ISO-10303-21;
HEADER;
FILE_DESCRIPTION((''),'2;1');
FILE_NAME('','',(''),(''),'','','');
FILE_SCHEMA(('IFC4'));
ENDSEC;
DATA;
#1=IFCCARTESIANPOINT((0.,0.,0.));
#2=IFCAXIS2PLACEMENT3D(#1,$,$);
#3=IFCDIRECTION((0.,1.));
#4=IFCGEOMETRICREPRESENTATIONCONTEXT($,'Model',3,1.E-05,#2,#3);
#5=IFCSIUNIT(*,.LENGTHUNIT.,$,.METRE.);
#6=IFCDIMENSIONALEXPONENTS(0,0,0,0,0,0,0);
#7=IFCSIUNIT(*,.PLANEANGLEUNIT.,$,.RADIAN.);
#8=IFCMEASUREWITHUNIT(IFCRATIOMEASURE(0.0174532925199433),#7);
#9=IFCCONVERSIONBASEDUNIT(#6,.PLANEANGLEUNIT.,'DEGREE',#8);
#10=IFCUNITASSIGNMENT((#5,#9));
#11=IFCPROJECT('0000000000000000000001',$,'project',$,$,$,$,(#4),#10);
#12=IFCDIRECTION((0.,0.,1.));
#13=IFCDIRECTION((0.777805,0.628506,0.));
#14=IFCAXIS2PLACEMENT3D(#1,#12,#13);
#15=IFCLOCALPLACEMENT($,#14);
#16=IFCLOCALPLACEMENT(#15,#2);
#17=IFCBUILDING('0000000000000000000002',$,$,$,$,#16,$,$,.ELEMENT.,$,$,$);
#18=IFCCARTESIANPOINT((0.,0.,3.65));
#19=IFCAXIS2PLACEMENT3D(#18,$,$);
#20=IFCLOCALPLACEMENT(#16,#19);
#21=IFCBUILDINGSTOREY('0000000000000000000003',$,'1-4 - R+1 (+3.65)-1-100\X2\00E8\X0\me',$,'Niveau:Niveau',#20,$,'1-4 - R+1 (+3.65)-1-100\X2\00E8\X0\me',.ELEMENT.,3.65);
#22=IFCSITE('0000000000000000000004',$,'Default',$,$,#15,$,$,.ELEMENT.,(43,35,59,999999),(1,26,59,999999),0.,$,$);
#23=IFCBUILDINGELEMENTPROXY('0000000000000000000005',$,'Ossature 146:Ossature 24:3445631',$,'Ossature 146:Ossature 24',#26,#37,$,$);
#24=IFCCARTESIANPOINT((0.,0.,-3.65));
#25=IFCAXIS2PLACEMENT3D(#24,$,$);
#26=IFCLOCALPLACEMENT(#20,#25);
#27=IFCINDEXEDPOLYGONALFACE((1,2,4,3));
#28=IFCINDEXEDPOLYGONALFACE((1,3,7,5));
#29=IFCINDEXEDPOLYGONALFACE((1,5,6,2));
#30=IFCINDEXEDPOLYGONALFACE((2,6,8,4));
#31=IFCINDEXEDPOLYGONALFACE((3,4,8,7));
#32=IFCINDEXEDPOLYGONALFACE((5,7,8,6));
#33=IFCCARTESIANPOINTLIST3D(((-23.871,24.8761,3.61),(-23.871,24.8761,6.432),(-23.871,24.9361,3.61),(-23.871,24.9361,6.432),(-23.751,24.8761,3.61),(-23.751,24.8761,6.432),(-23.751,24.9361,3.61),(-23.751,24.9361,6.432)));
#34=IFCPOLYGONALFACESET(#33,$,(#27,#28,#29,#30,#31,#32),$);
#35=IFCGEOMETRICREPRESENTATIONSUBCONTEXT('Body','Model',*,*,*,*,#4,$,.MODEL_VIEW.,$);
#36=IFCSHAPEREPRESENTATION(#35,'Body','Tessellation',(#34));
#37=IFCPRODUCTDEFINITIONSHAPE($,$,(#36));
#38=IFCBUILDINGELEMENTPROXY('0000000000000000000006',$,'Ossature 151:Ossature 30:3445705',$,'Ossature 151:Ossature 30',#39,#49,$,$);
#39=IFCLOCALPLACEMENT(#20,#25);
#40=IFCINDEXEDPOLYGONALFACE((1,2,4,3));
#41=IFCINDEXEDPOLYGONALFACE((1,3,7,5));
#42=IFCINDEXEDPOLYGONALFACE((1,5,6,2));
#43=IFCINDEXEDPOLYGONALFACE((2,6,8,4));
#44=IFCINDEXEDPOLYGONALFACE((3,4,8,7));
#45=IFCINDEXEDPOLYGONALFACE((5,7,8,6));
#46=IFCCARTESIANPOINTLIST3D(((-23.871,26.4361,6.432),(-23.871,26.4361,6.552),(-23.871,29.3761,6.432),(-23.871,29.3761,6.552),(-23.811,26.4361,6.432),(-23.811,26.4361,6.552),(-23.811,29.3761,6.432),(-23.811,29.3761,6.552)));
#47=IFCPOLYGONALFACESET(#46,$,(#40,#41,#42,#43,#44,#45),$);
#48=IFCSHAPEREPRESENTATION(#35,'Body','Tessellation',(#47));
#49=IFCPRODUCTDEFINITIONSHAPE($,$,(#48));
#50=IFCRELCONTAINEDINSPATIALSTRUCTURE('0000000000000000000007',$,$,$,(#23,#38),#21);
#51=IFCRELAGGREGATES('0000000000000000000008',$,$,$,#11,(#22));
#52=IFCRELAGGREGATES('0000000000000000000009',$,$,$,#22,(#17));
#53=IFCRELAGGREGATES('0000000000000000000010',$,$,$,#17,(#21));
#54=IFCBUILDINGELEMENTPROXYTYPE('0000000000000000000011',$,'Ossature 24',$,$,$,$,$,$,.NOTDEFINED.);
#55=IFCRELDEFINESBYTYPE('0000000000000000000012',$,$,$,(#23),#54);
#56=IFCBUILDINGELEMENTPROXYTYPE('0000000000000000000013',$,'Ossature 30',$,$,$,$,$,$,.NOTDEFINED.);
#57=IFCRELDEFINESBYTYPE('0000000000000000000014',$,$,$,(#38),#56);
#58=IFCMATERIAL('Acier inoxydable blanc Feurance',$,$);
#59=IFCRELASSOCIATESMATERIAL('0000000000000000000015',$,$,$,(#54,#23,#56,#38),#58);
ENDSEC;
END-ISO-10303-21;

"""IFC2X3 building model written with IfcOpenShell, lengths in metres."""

from ifc_helpers import new_model, entity, si_unit, converted_unit, direction, frame, frame_2d, origin, origin_2d_with_axis, place, context, subcontext, project, spatial, rectangle, extrude, source, transform, mapped, material, type_object, type_shapes, element, save


model = new_model("IFC2X3")

# Units and contexts
model_context = context("Model", 3, precision=1e-05, world=origin(), true_north=direction((0.0, 1.0)))
body_context = subcontext(model_context, "Body", "Model", "MODEL_VIEW")
ifc_project = project(units=[si_unit("LENGTHUNIT", "METRE"), converted_unit("PLANEANGLEUNIT", "DEGREE", entity("IfcRatioMeasure", 0.0174532925199433), si_unit("PLANEANGLEUNIT", "RADIAN"), dimensions=[0, 0, 0, 0, 0, 0, 0])], contexts=[model_context])

# Site, building, storey
site_placement = place(None, frame((0.0, 0.0, 0.0), z_axis=(0.0, 0.0, 1.0), x_axis=(0.777805, 0.628506, 0.0)))
site = spatial("IfcSite", under=ifc_project, at=site_placement, Name="Default", CompositionType="ELEMENT", RefLatitude=(43, 35, 59, 999999), RefLongitude=(1, 26, 59, 999999), RefElevation=0.0)
building_placement = place(site_placement, origin())
building = spatial("IfcBuilding", under=site, at=building_placement, CompositionType="ELEMENT")
storey_placement = place(building_placement, frame((0.0, 0.0, 3.65)))
storey = spatial("IfcBuildingStorey", under=building, at=storey_placement, Name="1-4 - R+1 (+3.65)-1-100ème", ObjectType="Niveau:Niveau", LongName="1-4 - R+1 (+3.65)-1-100ème", CompositionType="ELEMENT", Elevation=3.65)

# Building element proxies
ifc_material_1 = material(Name="Acier inoxydable blanc Feurance")
building_element_proxy_type_1 = type_object("IfcBuildingElementProxyType", Name="Ossature 24", PredefinedType="NOTDEFINED", material=ifc_material_1)
shared_shape_1 = source(origin(), body_context, "Body", "SweptSolid", [
    extrude(rectangle(XDim=0.06, YDim=0.12, at=frame_2d((0.0, 0.0), x_axis=(1.0, 0.0))), frame((-23.811, 24.9061, 3.61), z_axis=(0.0, 0.0, 1.0), x_axis=(0.0, -1.0, 0.0)), (0.0, 0.0, 1.0), 2.822),
])
type_shapes(building_element_proxy_type_1, [shared_shape_1])
proxy_1_placement = place(storey_placement, frame((0.0, 0.0, -3.65)))
element("IfcBuildingElementProxy", 1, at=proxy_1_placement, inside=storey, type_object=building_element_proxy_type_1, material=ifc_material_1, Name="Ossature 146:Ossature 24:3445631", ObjectType="Ossature 146:Ossature 24", context=body_context, shape_type="MappedRepresentation", body=[
    mapped(shared_shape_1, transform((0.0, 0.0, 0.0), scale=1.0)),
])
building_element_proxy_type_2 = type_object("IfcBuildingElementProxyType", Name="Ossature 30", PredefinedType="NOTDEFINED", material=ifc_material_1)
shared_shape_2 = source(origin(), body_context, "Body", "SweptSolid", [
    extrude(rectangle(XDim=2.94, YDim=0.06, at=origin_2d_with_axis()), frame((-23.841, 27.9061, 6.432), z_axis=(0.0, 0.0, 1.0), x_axis=(0.0, -1.0, 0.0)), (0.0, 0.0, 1.0), 0.12),
])
type_shapes(building_element_proxy_type_2, [shared_shape_2])
proxy_2_placement = place(storey_placement, frame((0.0, 0.0, -3.65)))
element("IfcBuildingElementProxy", 2, at=proxy_2_placement, inside=storey, type_object=building_element_proxy_type_2, material=ifc_material_1, Name="Ossature 151:Ossature 30:3445705", ObjectType="Ossature 151:Ossature 30", context=body_context, shape_type="MappedRepresentation", body=[
    mapped(shared_shape_2, transform((0.0, 0.0, 0.0), scale=1.0)),
])

save(model, "model.ifc")
